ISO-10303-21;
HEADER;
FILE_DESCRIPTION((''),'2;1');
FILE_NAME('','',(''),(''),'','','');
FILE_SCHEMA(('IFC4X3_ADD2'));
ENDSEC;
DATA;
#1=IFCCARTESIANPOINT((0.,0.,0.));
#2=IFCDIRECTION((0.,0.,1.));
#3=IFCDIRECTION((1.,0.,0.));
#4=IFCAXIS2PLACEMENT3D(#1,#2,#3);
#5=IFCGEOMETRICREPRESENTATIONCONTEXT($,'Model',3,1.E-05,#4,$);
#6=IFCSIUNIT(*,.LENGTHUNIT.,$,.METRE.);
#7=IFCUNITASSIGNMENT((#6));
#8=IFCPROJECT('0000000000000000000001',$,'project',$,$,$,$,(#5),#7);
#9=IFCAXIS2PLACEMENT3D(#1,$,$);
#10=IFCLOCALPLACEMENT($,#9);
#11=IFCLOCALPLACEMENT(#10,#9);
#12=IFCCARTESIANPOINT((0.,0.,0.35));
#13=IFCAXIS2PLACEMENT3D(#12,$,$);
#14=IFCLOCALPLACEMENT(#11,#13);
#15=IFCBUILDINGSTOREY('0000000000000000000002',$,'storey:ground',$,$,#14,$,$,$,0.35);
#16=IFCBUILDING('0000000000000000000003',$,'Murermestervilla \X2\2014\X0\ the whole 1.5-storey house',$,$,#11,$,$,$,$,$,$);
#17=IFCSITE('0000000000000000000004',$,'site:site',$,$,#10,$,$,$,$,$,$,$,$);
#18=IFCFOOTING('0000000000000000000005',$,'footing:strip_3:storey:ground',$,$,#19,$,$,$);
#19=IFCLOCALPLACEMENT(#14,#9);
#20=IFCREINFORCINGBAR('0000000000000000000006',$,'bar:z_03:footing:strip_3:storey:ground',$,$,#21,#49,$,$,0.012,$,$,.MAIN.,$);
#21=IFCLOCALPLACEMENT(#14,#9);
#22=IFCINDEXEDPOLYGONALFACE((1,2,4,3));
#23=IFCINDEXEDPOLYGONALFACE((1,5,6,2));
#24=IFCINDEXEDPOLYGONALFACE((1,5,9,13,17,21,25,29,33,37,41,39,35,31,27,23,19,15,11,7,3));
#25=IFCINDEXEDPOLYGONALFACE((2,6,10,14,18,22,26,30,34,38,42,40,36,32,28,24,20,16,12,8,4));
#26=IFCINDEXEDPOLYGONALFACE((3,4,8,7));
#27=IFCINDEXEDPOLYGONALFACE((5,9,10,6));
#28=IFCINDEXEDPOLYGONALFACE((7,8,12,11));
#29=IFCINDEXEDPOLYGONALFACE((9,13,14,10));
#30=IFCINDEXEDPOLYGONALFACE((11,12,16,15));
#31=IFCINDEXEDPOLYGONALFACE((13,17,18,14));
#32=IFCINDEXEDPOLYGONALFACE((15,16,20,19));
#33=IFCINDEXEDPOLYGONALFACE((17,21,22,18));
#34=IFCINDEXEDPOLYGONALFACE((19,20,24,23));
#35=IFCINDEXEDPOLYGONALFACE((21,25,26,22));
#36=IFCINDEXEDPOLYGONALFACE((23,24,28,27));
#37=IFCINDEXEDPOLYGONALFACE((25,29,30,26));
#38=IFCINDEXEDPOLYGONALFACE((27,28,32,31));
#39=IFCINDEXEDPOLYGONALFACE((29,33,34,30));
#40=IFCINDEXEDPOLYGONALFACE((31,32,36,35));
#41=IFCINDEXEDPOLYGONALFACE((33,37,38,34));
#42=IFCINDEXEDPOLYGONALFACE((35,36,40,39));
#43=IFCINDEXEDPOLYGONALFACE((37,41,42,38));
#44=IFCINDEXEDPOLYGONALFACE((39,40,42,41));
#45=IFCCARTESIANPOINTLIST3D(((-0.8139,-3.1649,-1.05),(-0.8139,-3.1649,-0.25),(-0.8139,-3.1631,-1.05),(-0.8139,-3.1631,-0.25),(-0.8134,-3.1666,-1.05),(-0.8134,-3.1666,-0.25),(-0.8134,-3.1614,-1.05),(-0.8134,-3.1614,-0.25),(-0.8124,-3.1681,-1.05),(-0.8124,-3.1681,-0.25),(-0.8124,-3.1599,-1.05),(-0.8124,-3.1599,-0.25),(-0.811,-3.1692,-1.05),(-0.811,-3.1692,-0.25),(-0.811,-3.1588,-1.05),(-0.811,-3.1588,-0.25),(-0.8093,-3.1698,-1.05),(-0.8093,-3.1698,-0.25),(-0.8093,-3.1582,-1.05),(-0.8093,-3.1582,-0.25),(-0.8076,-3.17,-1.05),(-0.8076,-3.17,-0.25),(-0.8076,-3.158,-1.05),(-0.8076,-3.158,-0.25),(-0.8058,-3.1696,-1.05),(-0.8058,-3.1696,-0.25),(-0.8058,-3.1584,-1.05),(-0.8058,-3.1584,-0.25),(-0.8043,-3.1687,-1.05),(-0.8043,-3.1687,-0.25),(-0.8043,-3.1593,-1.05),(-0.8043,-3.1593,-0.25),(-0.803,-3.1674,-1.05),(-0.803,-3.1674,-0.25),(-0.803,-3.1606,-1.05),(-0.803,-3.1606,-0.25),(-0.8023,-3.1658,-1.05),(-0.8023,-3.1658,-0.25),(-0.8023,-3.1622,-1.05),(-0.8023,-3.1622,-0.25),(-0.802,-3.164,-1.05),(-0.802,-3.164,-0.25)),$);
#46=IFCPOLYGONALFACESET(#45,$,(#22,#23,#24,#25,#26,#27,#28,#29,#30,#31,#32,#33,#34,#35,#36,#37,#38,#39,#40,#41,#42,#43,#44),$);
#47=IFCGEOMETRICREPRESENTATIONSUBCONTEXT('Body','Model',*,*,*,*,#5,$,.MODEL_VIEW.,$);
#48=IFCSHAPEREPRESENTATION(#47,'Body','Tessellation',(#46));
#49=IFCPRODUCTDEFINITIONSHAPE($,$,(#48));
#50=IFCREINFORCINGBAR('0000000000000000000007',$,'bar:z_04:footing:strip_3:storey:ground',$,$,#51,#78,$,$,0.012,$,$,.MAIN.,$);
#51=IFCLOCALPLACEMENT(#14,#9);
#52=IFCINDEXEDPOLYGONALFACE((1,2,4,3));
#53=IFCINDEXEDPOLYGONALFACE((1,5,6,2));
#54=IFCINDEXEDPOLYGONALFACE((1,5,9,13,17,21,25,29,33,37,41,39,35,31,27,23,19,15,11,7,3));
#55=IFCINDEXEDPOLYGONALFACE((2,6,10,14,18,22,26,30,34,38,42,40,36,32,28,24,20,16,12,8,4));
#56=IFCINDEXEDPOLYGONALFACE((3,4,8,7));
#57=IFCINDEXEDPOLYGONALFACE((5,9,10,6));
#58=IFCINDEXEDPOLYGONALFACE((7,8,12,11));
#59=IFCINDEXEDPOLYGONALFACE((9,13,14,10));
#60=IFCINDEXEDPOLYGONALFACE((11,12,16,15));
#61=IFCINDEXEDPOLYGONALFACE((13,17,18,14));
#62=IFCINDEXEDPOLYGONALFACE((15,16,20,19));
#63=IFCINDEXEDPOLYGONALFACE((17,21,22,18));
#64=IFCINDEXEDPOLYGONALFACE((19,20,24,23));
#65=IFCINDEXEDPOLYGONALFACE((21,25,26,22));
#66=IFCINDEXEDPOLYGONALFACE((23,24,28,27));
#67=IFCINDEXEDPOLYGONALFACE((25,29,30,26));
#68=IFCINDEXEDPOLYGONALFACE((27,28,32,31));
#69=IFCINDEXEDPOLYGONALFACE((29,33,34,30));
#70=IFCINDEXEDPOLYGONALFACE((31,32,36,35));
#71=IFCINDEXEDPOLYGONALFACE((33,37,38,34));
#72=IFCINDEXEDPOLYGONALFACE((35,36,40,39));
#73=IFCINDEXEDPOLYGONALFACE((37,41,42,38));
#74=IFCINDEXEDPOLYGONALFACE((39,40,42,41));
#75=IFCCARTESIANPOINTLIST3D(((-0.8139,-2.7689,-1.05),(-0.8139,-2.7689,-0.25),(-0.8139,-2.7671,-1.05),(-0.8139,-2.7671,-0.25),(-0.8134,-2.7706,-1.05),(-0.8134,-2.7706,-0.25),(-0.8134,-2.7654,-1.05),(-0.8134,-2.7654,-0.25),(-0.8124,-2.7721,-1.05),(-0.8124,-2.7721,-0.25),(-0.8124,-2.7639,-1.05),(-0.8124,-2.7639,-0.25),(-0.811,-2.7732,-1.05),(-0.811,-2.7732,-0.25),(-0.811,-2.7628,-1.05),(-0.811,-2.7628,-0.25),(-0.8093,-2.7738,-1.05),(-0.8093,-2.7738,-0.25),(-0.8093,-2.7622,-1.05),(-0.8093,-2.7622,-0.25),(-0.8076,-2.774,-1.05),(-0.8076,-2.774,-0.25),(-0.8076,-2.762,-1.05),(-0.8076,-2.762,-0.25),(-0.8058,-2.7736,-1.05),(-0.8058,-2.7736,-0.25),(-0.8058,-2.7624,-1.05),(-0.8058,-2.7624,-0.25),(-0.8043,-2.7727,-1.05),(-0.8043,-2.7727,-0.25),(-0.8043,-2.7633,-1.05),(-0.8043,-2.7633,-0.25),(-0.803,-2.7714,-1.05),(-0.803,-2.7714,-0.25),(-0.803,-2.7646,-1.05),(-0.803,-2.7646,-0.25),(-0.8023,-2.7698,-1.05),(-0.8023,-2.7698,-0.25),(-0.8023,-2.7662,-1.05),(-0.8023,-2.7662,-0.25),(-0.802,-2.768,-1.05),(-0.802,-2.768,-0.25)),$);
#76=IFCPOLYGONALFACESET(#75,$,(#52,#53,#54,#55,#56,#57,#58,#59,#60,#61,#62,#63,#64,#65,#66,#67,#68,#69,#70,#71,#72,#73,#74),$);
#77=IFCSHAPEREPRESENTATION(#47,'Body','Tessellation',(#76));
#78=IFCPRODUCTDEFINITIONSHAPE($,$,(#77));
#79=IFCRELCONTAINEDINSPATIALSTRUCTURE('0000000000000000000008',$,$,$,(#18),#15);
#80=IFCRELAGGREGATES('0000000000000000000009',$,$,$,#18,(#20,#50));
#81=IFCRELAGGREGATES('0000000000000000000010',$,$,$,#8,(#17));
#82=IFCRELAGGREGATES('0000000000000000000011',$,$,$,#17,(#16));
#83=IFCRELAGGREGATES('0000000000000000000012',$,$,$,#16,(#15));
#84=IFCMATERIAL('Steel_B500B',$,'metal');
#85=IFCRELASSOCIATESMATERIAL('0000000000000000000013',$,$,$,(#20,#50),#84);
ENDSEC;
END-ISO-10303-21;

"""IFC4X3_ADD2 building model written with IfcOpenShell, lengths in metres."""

from ifc_helpers import new_model, entity, si_unit, frame, origin, origin_with_axes, place, context, subcontext, project, spatial, material, element, aggregate, save


model = new_model("IFC4X3_ADD2")

# Units and contexts
model_context = context("Model", 3, precision=1e-05, world=origin_with_axes())
body_context = subcontext(model_context, "Body", "Model", "MODEL_VIEW")
ifc_project = project(units=[si_unit("LENGTHUNIT", "METRE")], contexts=[model_context])

# Site, building, storey
placement_1 = place(None, origin())
site = spatial("IfcSite", under=ifc_project, at=placement_1, Name="site:site")
building_placement = place(placement_1, origin())
building = spatial("IfcBuilding", under=site, at=building_placement, Name="Murermestervilla — the whole 1.5-storey house")
storey_placement = place(building_placement, frame((0.0, 0.0, 0.35)))
storey = spatial("IfcBuildingStorey", under=building, at=storey_placement, Name="storey:ground", Elevation=0.35)

# Footing, reinforcing bars
placement_2 = place(storey_placement, frame((0.0, 0.0, -0.35)))
ifc_material = material(Name="Steel_B500B", Category="metal")
footing_1 = element("IfcFooting", 1, at=placement_2, inside=storey, Name="footing:strip_3:storey:ground")
reinforcing_bar_1 = element("IfcReinforcingBar", 2, at=placement_1, material=ifc_material, Name="bar:z_03:footing:strip_3:storey:ground", NominalDiameter=0.012, PredefinedType="MAIN", context=body_context, shape_type="AdvancedSweptSolid", body=[
    entity("IfcSweptDiskSolid", entity("IfcPolyline", [entity("IfcCartesianPoint", [-0.808, -3.164, -0.7]), entity("IfcCartesianPoint", [-0.808, -3.164, 0.1])]), 0.006),
])
reinforcing_bar_2 = element("IfcReinforcingBar", 3, at=placement_1, material=ifc_material, Name="bar:z_04:footing:strip_3:storey:ground", NominalDiameter=0.012, PredefinedType="MAIN", context=body_context, shape_type="AdvancedSweptSolid", body=[
    entity("IfcSweptDiskSolid", entity("IfcPolyline", [entity("IfcCartesianPoint", [-0.808, -2.768, -0.7]), entity("IfcCartesianPoint", [-0.808, -2.768, 0.1])]), 0.006),
])
aggregate(footing_1, [reinforcing_bar_1, reinforcing_bar_2])

save(model, "model.ifc")
